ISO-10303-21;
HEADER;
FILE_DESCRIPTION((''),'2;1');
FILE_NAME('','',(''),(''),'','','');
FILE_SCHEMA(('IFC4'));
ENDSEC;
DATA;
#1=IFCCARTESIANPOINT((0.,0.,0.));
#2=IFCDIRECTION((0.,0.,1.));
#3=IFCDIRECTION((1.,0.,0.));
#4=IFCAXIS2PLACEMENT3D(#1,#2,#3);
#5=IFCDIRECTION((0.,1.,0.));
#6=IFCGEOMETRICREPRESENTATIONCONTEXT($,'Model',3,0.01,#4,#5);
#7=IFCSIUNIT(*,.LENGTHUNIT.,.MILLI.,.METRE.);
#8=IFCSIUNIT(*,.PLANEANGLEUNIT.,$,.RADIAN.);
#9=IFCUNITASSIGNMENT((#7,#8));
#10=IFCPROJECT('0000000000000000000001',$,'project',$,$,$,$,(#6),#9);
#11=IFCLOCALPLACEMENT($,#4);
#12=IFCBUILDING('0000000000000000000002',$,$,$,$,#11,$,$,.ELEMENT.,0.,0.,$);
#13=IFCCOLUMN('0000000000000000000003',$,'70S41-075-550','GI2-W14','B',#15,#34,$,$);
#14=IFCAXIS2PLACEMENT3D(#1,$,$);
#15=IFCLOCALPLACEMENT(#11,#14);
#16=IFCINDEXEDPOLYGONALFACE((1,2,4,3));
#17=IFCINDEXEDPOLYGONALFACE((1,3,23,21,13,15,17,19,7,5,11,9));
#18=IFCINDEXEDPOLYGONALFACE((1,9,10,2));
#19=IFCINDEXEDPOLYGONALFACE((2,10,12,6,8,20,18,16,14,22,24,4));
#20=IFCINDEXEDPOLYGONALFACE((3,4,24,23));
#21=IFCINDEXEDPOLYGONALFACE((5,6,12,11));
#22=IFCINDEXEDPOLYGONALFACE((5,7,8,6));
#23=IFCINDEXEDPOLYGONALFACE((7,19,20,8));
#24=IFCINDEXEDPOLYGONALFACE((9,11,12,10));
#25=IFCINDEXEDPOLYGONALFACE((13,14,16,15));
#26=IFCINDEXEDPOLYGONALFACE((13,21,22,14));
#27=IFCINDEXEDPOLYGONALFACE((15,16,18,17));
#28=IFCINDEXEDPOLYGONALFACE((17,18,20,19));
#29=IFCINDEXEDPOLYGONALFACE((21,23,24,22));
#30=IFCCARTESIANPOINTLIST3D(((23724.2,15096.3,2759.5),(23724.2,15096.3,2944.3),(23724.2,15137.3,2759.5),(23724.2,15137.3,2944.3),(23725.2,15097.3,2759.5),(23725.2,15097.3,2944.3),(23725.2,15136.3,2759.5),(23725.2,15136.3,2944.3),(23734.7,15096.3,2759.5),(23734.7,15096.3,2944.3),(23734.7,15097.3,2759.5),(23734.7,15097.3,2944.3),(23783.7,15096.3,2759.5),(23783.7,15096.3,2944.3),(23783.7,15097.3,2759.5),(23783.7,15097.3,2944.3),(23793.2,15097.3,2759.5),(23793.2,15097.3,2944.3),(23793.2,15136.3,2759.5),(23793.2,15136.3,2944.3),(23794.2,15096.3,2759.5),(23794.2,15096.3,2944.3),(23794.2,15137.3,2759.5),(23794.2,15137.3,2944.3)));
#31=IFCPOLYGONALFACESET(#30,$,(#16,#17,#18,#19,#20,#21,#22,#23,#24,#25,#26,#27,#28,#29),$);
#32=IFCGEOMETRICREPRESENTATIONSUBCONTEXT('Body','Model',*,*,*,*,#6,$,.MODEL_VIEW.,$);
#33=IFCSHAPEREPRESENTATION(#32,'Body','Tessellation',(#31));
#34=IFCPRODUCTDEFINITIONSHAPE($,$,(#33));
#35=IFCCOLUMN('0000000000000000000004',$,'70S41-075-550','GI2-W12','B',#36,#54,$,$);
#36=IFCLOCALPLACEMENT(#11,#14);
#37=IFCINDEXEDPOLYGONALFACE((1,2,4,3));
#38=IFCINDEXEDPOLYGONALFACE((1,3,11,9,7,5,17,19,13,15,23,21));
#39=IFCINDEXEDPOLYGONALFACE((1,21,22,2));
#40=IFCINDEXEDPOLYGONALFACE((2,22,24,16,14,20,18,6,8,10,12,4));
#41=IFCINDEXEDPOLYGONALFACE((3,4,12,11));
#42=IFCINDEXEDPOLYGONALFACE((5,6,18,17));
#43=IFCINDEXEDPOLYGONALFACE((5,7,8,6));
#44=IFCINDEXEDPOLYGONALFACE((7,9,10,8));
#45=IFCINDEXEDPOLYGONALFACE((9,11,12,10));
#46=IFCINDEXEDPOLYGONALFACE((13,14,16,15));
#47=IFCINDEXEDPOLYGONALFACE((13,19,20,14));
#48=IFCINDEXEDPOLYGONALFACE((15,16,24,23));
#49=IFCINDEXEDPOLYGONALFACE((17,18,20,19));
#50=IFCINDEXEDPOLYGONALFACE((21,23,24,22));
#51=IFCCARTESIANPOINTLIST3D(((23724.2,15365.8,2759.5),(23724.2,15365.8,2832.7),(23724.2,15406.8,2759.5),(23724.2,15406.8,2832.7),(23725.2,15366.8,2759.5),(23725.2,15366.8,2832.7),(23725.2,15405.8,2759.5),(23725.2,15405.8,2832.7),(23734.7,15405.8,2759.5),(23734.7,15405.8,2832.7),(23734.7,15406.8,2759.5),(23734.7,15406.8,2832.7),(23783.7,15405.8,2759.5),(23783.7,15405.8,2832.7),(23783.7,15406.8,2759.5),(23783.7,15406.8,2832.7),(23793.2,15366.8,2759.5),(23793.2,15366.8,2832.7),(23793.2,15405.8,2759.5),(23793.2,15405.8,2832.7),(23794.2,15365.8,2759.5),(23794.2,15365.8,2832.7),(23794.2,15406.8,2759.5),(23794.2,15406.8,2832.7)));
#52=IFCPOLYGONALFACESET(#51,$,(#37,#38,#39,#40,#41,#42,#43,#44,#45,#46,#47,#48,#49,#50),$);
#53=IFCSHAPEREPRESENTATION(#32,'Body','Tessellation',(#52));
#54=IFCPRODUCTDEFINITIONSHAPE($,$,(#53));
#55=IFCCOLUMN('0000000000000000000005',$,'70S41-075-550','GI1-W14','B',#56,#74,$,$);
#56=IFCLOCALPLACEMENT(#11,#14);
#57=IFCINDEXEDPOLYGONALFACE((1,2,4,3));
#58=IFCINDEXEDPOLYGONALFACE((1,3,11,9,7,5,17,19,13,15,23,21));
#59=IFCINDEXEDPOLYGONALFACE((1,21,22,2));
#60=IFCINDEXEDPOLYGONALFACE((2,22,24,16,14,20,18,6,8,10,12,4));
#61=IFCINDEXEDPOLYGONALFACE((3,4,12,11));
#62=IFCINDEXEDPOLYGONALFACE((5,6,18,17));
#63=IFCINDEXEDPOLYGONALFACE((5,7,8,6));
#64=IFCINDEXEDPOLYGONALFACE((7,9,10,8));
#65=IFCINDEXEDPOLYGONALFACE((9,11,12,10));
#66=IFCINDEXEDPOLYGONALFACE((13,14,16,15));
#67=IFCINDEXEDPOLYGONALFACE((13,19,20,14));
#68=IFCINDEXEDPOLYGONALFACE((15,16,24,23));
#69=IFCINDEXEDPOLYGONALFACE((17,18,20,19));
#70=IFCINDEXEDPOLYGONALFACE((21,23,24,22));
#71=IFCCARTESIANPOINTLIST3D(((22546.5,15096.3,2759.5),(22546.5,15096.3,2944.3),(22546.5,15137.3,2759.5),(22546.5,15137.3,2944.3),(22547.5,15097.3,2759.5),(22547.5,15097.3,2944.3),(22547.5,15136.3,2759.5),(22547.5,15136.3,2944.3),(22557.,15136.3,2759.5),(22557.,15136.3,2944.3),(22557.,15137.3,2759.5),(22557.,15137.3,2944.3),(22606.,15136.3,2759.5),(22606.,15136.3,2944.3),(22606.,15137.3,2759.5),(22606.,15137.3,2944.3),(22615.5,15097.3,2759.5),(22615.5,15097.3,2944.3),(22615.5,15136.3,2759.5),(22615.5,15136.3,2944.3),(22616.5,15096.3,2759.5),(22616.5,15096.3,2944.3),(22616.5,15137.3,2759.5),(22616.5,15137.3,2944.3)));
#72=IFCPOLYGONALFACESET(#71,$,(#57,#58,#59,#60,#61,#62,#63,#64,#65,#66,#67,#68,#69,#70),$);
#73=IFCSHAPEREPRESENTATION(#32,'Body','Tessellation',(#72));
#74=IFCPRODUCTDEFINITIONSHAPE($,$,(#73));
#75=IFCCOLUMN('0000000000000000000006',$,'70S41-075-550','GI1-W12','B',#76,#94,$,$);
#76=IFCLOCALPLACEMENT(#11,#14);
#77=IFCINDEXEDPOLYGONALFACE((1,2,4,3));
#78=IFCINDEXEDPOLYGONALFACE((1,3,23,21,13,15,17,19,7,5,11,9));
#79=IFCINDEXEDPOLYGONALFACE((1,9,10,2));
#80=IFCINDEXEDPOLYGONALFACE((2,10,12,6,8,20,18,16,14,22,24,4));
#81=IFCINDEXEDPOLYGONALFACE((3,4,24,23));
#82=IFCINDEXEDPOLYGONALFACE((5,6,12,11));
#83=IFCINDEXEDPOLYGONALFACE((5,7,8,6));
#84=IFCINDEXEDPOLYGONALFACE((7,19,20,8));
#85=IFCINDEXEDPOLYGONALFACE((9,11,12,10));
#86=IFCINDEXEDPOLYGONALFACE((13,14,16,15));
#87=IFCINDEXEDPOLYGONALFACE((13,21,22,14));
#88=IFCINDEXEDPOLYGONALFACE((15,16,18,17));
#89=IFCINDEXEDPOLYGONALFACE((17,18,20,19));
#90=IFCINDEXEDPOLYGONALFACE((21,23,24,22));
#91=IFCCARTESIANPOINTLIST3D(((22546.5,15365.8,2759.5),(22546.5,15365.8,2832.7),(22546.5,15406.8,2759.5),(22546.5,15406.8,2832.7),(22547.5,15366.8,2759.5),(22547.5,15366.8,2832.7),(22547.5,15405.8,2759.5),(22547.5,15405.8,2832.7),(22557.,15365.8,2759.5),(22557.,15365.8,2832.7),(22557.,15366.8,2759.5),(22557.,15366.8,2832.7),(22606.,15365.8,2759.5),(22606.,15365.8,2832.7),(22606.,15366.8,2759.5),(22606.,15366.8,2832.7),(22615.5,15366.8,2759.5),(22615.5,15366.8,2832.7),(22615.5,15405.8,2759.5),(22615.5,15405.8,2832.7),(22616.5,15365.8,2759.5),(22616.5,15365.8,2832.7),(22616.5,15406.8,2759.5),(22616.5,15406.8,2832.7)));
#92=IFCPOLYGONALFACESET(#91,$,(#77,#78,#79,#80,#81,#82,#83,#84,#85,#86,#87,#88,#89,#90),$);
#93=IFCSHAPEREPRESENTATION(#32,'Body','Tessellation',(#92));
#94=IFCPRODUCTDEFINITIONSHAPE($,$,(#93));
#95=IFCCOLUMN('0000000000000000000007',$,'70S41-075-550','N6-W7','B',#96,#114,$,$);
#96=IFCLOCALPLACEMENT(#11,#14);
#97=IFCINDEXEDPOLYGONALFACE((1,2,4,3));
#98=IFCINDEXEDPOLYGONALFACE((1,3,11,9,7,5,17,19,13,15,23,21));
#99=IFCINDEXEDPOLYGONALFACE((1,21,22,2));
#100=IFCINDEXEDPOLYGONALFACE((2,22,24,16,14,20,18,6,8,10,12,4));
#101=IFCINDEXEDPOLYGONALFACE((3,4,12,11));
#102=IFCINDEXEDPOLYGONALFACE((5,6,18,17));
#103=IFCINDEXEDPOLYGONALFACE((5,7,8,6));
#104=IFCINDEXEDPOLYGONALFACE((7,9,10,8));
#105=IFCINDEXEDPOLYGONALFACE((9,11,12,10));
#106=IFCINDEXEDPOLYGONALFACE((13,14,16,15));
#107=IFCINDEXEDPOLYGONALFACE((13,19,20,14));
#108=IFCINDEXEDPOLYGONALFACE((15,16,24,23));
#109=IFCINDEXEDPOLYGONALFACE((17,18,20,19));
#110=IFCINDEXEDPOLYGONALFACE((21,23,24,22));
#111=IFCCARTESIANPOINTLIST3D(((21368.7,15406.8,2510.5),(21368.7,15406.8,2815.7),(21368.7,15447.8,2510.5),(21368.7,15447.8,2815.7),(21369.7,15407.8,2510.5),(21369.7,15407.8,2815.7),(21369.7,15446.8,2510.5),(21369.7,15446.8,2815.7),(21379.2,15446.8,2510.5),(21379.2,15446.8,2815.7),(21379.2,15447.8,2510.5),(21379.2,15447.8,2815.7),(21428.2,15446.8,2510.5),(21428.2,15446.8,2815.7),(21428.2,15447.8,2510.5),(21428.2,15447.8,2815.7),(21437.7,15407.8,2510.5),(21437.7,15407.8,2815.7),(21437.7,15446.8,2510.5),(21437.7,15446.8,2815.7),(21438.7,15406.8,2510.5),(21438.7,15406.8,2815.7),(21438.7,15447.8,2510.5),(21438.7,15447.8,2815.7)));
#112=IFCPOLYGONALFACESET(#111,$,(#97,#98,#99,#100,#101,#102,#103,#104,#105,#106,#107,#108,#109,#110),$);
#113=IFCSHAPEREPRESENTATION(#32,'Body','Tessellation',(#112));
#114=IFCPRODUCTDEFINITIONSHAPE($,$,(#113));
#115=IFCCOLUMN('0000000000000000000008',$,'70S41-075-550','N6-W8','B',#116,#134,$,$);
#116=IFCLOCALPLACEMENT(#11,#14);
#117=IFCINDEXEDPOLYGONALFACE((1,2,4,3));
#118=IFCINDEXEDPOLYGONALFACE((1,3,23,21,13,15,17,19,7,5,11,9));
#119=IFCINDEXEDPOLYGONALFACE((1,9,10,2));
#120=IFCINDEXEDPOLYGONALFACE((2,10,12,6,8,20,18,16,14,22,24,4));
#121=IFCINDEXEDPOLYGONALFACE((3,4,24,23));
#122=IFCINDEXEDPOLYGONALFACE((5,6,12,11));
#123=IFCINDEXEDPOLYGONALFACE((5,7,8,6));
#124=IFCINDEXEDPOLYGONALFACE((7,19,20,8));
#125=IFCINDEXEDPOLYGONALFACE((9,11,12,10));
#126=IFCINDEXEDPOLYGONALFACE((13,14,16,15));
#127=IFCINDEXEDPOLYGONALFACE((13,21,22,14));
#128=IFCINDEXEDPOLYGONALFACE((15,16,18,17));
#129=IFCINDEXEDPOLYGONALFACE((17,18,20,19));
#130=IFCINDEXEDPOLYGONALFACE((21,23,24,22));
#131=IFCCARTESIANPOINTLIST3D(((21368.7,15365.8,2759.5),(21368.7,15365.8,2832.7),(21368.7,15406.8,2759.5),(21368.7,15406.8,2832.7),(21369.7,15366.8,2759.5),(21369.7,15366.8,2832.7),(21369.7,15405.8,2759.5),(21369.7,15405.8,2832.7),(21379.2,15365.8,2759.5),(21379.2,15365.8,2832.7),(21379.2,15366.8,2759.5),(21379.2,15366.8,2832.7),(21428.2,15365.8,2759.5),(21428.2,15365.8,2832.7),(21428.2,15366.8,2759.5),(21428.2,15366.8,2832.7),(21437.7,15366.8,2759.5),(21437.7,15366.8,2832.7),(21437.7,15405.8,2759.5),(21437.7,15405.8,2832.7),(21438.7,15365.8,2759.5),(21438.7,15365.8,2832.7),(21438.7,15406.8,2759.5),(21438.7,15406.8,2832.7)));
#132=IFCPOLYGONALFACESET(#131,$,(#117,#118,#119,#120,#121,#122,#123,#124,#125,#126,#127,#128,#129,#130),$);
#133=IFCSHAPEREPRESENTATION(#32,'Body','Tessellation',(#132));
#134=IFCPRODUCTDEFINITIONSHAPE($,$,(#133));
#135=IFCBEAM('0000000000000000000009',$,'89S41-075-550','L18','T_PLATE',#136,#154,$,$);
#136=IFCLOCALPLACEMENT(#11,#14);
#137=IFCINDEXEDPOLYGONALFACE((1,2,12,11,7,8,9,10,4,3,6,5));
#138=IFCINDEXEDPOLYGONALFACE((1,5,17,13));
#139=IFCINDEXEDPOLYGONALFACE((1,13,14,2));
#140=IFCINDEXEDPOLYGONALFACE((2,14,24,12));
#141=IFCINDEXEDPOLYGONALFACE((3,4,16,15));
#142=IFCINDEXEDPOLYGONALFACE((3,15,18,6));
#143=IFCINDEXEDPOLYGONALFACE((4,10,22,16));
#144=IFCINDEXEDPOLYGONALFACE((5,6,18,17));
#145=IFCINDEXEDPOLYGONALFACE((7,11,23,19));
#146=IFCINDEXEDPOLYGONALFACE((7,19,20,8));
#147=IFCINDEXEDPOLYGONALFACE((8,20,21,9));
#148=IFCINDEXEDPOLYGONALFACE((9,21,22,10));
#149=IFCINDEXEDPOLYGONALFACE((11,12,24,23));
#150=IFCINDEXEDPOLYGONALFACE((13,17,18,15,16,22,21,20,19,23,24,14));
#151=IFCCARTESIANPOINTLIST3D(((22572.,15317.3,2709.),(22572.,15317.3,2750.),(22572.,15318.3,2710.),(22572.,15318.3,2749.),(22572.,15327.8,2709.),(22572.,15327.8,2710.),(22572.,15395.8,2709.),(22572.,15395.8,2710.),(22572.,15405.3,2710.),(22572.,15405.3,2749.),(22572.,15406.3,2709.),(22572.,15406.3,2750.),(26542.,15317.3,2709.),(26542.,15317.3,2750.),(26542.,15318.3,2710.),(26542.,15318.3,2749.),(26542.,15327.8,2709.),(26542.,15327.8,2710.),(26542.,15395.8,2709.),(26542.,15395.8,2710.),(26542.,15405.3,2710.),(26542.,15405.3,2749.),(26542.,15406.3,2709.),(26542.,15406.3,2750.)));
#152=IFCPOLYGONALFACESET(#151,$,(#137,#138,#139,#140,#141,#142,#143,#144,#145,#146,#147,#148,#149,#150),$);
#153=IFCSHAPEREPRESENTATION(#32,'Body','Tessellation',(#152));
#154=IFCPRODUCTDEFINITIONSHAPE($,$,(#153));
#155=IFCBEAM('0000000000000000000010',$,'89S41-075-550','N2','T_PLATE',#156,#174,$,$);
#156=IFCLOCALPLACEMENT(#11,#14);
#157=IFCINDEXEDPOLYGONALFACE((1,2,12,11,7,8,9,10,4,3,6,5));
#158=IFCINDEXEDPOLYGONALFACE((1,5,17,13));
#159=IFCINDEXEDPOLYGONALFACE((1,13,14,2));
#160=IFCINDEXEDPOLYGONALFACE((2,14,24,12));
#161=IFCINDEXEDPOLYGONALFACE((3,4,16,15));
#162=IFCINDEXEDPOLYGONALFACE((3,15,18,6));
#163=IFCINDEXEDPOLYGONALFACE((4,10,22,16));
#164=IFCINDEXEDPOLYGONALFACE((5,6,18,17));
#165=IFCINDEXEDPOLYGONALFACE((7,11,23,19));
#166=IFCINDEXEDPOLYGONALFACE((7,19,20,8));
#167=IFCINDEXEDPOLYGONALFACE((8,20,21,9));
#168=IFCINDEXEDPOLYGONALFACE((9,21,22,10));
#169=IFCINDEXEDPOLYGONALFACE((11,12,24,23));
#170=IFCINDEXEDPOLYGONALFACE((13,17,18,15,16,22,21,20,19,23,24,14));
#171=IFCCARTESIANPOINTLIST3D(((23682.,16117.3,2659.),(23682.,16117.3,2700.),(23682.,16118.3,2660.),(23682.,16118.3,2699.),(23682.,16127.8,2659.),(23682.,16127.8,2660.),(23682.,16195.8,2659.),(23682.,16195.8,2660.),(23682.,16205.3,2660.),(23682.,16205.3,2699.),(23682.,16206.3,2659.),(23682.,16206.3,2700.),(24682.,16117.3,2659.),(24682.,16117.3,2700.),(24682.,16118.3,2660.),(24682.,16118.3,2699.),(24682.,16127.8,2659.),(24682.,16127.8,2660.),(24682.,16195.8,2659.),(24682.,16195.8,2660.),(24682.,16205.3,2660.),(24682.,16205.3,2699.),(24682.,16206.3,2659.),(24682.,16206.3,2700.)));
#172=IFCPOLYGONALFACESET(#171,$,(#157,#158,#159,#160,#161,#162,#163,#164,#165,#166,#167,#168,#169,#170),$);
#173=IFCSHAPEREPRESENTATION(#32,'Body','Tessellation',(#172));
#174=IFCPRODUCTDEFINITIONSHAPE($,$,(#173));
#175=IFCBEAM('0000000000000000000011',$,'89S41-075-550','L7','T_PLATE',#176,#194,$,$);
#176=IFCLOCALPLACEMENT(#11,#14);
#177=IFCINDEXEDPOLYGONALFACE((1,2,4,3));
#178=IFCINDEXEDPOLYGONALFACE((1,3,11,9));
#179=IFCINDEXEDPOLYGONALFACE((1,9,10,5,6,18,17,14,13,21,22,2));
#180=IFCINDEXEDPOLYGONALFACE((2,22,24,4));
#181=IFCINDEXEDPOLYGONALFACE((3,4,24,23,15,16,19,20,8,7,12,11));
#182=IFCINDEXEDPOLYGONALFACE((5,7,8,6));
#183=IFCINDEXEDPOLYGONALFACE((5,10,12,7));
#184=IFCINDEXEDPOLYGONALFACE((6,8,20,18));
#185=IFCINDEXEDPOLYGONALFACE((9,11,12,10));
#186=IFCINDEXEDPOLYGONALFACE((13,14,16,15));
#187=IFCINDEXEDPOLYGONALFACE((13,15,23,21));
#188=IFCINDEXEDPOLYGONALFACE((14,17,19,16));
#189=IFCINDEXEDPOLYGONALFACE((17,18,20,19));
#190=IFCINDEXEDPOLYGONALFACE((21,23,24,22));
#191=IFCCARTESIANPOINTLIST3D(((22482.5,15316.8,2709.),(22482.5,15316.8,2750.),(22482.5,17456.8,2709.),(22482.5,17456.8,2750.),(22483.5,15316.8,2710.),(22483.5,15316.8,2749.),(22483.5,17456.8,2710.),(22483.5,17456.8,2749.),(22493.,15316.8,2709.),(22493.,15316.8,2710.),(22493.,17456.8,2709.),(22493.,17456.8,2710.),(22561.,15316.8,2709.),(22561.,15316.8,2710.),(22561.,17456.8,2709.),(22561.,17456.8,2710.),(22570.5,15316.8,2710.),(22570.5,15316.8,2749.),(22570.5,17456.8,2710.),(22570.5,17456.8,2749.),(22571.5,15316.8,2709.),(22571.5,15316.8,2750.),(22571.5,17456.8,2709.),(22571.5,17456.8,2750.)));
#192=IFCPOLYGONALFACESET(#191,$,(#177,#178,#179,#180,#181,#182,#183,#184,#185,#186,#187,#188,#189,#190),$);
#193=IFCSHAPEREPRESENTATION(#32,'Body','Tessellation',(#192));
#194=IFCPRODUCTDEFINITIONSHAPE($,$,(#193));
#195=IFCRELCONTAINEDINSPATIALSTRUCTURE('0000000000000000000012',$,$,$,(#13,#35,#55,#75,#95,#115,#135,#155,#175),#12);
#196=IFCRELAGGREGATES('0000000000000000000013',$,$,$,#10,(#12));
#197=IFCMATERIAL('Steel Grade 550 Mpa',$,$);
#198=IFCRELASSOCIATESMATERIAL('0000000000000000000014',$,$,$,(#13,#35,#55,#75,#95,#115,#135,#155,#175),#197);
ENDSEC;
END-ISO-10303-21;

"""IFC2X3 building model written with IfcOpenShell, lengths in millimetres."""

from ifc_helpers import new_model, si_unit, direction, frame, origin, origin_with_axes, origin_2d_with_axis, place, context, subcontext, project, spatial, c_section, extrude, source, transform, mapped, material, element, save


model = new_model("IFC2X3")

# Units and contexts
model_context = context("Model", 3, precision=0.01, world=origin_with_axes(), true_north=direction((0.0, 1.0, 0.0)))
body_context = subcontext(model_context, "Body", "Model", "MODEL_VIEW")
ifc_project = project(units=[si_unit("LENGTHUNIT", "METRE", prefix="MILLI"), si_unit("PLANEANGLEUNIT", "RADIAN")], contexts=[model_context])

# Building
building_placement = place(None, origin_with_axes())
building = spatial("IfcBuilding", under=ifc_project, at=building_placement, CompositionType="ELEMENT", ElevationOfRefHeight=0.0, ElevationOfTerrain=0.0)

# Columns
ifc_material = material(Name="Steel Grade 550 Mpa")
shared_shape_1 = source(origin(), body_context, "Body", "SweptSolid", [
    extrude(c_section(Depth=70.0, Width=41.0, WallThickness=1.0, Girth=10.5, at=origin_2d_with_axis()), origin_with_axes(), (0.0, 0.0, 1.0), 184.8),
])
column_1_placement = place(None, frame((23759.2, 15116.8, 2759.5), z_axis=(0.0, 0.0, 1.0), x_axis=(0.000004, -1.0, 0.0)))
element("IfcColumn", 1, at=column_1_placement, inside=building, material=ifc_material, Name="70S41-075-550", Description="GI2-W14", ObjectType="B", context=body_context, shape_type="MappedRepresentation", body=[
    mapped(shared_shape_1, transform((0.0, 0.0, 0.0), scale=1.0)),
])
shared_shape_2 = source(origin(), body_context, "Body", "SweptSolid", [
    extrude(c_section(Depth=70.0, Width=41.0, WallThickness=1.0, Girth=10.5, at=origin_2d_with_axis()), origin_with_axes(), (0.0, 0.0, 1.0), 73.2),
])
column_2_placement = place(None, frame((23759.2, 15386.3, 2832.7), z_axis=(0.0, 0.0, -1.0), x_axis=(-0.000004, 1.0, 0.0)))
element("IfcColumn", 2, at=column_2_placement, inside=building, material=ifc_material, Name="70S41-075-550", Description="GI2-W12", ObjectType="B", context=body_context, shape_type="MappedRepresentation", body=[
    mapped(shared_shape_2, transform((0.0, 0.0, 0.0), scale=1.0)),
])
shared_shape_3 = source(origin(), body_context, "Body", "SweptSolid", [
    extrude(c_section(Depth=70.0, Width=41.0, WallThickness=1.0, Girth=10.5, at=origin_2d_with_axis()), origin_with_axes(), (0.0, 0.0, 1.0), 184.8),
])
column_3_placement = place(None, frame((22581.5, 15116.8, 2944.3), z_axis=(0.0, 0.0, -1.0), x_axis=(-0.000004, 1.0, 0.0)))
element("IfcColumn", 3, at=column_3_placement, inside=building, material=ifc_material, Name="70S41-075-550", Description="GI1-W14", ObjectType="B", context=body_context, shape_type="MappedRepresentation", body=[
    mapped(shared_shape_3, transform((0.0, 0.0, 0.0), scale=1.0)),
])
shared_shape_4 = source(origin(), body_context, "Body", "SweptSolid", [
    extrude(c_section(Depth=70.0, Width=41.0, WallThickness=1.0, Girth=10.5, at=origin_2d_with_axis()), origin_with_axes(), (0.0, 0.0, 1.0), 73.2),
])
column_4_placement = place(None, frame((22581.5, 15386.3, 2759.5), z_axis=(0.0, 0.0, 1.0), x_axis=(0.000004, -1.0, 0.0)))
element("IfcColumn", 4, at=column_4_placement, inside=building, material=ifc_material, Name="70S41-075-550", Description="GI1-W12", ObjectType="B", context=body_context, shape_type="MappedRepresentation", body=[
    mapped(shared_shape_4, transform((0.0, 0.0, 0.0), scale=1.0)),
])
shared_shape_5 = source(origin(), body_context, "Body", "SweptSolid", [
    extrude(c_section(Depth=70.0, Width=41.0, WallThickness=1.0, Girth=10.5, at=origin_2d_with_axis()), origin_with_axes(), (0.0, 0.0, 1.0), 305.2),
])
column_5_placement = place(None, frame((21403.7, 15427.3, 2815.7), z_axis=(0.0, 0.0, -1.0), x_axis=(-0.000004, 1.0, 0.0)))
element("IfcColumn", 5, at=column_5_placement, inside=building, material=ifc_material, Name="70S41-075-550", Description="N6-W7", ObjectType="B", context=body_context, shape_type="MappedRepresentation", body=[
    mapped(shared_shape_5, transform((0.0, 0.0, 0.0), scale=1.0)),
])
shared_shape_6 = source(origin(), body_context, "Body", "SweptSolid", [
    extrude(c_section(Depth=70.0, Width=41.0, WallThickness=1.0, Girth=10.5, at=origin_2d_with_axis()), origin_with_axes(), (0.0, 0.0, 1.0), 73.2),
])
column_6_placement = place(None, frame((21403.7, 15386.3, 2759.5), z_axis=(0.0, 0.0, 1.0), x_axis=(0.000004, -1.0, 0.0)))
element("IfcColumn", 6, at=column_6_placement, inside=building, material=ifc_material, Name="70S41-075-550", Description="N6-W8", ObjectType="B", context=body_context, shape_type="MappedRepresentation", body=[
    mapped(shared_shape_6, transform((0.0, 0.0, 0.0), scale=1.0)),
])

# Beams
shared_shape_7 = source(origin(), body_context, "Body", "SweptSolid", [
    extrude(c_section(Depth=89.0, Width=41.0, WallThickness=1.0, Girth=10.5, at=origin_2d_with_axis()), origin_with_axes(), (0.0, 0.0, 1.0), 3969.9),
])
beam_1_placement = place(None, frame((22572.0, 15361.8, 2729.5), z_axis=(1.0, 0.0, 0.0), x_axis=(0.0, 0.0, -1.0)))
element("IfcBeam", 7, at=beam_1_placement, inside=building, material=ifc_material, Name="89S41-075-550", Description="L18", ObjectType="T_PLATE", context=body_context, shape_type="MappedRepresentation", body=[
    mapped(shared_shape_7, transform((0.0, 0.0, 0.0), scale=1.0)),
])
shared_shape_8 = source(origin(), body_context, "Body", "SweptSolid", [
    extrude(c_section(Depth=89.0, Width=41.0, WallThickness=1.0, Girth=10.5, at=origin_2d_with_axis()), origin_with_axes(), (0.0, 0.0, 1.0), 1000.0),
])
beam_2_placement = place(None, frame((23682.0, 16161.8, 2679.5), z_axis=(1.0, 0.0, 0.0), x_axis=(0.0, 0.0, -1.0)))
element("IfcBeam", 8, at=beam_2_placement, inside=building, material=ifc_material, Name="89S41-075-550", Description="N2", ObjectType="T_PLATE", context=body_context, shape_type="MappedRepresentation", body=[
    mapped(shared_shape_8, transform((0.0, 0.0, 0.0), scale=1.0)),
])
shared_shape_9 = source(origin(), body_context, "Body", "SweptSolid", [
    extrude(c_section(Depth=89.0, Width=41.0, WallThickness=1.0, Girth=10.5, at=origin_2d_with_axis()), origin_with_axes(), (0.0, 0.0, 1.0), 2140.0),
])
beam_3_placement = place(None, frame((22527.0, 15316.8, 2729.5), z_axis=(0.0, 1.0, 0.0), x_axis=(0.0, 0.0, -1.0)))
element("IfcBeam", 9, at=beam_3_placement, inside=building, material=ifc_material, Name="89S41-075-550", Description="L7", ObjectType="T_PLATE", context=body_context, shape_type="MappedRepresentation", body=[
    mapped(shared_shape_9, transform((0.0, 0.0, 0.0), scale=1.0)),
])

save(model, "model.ifc")
